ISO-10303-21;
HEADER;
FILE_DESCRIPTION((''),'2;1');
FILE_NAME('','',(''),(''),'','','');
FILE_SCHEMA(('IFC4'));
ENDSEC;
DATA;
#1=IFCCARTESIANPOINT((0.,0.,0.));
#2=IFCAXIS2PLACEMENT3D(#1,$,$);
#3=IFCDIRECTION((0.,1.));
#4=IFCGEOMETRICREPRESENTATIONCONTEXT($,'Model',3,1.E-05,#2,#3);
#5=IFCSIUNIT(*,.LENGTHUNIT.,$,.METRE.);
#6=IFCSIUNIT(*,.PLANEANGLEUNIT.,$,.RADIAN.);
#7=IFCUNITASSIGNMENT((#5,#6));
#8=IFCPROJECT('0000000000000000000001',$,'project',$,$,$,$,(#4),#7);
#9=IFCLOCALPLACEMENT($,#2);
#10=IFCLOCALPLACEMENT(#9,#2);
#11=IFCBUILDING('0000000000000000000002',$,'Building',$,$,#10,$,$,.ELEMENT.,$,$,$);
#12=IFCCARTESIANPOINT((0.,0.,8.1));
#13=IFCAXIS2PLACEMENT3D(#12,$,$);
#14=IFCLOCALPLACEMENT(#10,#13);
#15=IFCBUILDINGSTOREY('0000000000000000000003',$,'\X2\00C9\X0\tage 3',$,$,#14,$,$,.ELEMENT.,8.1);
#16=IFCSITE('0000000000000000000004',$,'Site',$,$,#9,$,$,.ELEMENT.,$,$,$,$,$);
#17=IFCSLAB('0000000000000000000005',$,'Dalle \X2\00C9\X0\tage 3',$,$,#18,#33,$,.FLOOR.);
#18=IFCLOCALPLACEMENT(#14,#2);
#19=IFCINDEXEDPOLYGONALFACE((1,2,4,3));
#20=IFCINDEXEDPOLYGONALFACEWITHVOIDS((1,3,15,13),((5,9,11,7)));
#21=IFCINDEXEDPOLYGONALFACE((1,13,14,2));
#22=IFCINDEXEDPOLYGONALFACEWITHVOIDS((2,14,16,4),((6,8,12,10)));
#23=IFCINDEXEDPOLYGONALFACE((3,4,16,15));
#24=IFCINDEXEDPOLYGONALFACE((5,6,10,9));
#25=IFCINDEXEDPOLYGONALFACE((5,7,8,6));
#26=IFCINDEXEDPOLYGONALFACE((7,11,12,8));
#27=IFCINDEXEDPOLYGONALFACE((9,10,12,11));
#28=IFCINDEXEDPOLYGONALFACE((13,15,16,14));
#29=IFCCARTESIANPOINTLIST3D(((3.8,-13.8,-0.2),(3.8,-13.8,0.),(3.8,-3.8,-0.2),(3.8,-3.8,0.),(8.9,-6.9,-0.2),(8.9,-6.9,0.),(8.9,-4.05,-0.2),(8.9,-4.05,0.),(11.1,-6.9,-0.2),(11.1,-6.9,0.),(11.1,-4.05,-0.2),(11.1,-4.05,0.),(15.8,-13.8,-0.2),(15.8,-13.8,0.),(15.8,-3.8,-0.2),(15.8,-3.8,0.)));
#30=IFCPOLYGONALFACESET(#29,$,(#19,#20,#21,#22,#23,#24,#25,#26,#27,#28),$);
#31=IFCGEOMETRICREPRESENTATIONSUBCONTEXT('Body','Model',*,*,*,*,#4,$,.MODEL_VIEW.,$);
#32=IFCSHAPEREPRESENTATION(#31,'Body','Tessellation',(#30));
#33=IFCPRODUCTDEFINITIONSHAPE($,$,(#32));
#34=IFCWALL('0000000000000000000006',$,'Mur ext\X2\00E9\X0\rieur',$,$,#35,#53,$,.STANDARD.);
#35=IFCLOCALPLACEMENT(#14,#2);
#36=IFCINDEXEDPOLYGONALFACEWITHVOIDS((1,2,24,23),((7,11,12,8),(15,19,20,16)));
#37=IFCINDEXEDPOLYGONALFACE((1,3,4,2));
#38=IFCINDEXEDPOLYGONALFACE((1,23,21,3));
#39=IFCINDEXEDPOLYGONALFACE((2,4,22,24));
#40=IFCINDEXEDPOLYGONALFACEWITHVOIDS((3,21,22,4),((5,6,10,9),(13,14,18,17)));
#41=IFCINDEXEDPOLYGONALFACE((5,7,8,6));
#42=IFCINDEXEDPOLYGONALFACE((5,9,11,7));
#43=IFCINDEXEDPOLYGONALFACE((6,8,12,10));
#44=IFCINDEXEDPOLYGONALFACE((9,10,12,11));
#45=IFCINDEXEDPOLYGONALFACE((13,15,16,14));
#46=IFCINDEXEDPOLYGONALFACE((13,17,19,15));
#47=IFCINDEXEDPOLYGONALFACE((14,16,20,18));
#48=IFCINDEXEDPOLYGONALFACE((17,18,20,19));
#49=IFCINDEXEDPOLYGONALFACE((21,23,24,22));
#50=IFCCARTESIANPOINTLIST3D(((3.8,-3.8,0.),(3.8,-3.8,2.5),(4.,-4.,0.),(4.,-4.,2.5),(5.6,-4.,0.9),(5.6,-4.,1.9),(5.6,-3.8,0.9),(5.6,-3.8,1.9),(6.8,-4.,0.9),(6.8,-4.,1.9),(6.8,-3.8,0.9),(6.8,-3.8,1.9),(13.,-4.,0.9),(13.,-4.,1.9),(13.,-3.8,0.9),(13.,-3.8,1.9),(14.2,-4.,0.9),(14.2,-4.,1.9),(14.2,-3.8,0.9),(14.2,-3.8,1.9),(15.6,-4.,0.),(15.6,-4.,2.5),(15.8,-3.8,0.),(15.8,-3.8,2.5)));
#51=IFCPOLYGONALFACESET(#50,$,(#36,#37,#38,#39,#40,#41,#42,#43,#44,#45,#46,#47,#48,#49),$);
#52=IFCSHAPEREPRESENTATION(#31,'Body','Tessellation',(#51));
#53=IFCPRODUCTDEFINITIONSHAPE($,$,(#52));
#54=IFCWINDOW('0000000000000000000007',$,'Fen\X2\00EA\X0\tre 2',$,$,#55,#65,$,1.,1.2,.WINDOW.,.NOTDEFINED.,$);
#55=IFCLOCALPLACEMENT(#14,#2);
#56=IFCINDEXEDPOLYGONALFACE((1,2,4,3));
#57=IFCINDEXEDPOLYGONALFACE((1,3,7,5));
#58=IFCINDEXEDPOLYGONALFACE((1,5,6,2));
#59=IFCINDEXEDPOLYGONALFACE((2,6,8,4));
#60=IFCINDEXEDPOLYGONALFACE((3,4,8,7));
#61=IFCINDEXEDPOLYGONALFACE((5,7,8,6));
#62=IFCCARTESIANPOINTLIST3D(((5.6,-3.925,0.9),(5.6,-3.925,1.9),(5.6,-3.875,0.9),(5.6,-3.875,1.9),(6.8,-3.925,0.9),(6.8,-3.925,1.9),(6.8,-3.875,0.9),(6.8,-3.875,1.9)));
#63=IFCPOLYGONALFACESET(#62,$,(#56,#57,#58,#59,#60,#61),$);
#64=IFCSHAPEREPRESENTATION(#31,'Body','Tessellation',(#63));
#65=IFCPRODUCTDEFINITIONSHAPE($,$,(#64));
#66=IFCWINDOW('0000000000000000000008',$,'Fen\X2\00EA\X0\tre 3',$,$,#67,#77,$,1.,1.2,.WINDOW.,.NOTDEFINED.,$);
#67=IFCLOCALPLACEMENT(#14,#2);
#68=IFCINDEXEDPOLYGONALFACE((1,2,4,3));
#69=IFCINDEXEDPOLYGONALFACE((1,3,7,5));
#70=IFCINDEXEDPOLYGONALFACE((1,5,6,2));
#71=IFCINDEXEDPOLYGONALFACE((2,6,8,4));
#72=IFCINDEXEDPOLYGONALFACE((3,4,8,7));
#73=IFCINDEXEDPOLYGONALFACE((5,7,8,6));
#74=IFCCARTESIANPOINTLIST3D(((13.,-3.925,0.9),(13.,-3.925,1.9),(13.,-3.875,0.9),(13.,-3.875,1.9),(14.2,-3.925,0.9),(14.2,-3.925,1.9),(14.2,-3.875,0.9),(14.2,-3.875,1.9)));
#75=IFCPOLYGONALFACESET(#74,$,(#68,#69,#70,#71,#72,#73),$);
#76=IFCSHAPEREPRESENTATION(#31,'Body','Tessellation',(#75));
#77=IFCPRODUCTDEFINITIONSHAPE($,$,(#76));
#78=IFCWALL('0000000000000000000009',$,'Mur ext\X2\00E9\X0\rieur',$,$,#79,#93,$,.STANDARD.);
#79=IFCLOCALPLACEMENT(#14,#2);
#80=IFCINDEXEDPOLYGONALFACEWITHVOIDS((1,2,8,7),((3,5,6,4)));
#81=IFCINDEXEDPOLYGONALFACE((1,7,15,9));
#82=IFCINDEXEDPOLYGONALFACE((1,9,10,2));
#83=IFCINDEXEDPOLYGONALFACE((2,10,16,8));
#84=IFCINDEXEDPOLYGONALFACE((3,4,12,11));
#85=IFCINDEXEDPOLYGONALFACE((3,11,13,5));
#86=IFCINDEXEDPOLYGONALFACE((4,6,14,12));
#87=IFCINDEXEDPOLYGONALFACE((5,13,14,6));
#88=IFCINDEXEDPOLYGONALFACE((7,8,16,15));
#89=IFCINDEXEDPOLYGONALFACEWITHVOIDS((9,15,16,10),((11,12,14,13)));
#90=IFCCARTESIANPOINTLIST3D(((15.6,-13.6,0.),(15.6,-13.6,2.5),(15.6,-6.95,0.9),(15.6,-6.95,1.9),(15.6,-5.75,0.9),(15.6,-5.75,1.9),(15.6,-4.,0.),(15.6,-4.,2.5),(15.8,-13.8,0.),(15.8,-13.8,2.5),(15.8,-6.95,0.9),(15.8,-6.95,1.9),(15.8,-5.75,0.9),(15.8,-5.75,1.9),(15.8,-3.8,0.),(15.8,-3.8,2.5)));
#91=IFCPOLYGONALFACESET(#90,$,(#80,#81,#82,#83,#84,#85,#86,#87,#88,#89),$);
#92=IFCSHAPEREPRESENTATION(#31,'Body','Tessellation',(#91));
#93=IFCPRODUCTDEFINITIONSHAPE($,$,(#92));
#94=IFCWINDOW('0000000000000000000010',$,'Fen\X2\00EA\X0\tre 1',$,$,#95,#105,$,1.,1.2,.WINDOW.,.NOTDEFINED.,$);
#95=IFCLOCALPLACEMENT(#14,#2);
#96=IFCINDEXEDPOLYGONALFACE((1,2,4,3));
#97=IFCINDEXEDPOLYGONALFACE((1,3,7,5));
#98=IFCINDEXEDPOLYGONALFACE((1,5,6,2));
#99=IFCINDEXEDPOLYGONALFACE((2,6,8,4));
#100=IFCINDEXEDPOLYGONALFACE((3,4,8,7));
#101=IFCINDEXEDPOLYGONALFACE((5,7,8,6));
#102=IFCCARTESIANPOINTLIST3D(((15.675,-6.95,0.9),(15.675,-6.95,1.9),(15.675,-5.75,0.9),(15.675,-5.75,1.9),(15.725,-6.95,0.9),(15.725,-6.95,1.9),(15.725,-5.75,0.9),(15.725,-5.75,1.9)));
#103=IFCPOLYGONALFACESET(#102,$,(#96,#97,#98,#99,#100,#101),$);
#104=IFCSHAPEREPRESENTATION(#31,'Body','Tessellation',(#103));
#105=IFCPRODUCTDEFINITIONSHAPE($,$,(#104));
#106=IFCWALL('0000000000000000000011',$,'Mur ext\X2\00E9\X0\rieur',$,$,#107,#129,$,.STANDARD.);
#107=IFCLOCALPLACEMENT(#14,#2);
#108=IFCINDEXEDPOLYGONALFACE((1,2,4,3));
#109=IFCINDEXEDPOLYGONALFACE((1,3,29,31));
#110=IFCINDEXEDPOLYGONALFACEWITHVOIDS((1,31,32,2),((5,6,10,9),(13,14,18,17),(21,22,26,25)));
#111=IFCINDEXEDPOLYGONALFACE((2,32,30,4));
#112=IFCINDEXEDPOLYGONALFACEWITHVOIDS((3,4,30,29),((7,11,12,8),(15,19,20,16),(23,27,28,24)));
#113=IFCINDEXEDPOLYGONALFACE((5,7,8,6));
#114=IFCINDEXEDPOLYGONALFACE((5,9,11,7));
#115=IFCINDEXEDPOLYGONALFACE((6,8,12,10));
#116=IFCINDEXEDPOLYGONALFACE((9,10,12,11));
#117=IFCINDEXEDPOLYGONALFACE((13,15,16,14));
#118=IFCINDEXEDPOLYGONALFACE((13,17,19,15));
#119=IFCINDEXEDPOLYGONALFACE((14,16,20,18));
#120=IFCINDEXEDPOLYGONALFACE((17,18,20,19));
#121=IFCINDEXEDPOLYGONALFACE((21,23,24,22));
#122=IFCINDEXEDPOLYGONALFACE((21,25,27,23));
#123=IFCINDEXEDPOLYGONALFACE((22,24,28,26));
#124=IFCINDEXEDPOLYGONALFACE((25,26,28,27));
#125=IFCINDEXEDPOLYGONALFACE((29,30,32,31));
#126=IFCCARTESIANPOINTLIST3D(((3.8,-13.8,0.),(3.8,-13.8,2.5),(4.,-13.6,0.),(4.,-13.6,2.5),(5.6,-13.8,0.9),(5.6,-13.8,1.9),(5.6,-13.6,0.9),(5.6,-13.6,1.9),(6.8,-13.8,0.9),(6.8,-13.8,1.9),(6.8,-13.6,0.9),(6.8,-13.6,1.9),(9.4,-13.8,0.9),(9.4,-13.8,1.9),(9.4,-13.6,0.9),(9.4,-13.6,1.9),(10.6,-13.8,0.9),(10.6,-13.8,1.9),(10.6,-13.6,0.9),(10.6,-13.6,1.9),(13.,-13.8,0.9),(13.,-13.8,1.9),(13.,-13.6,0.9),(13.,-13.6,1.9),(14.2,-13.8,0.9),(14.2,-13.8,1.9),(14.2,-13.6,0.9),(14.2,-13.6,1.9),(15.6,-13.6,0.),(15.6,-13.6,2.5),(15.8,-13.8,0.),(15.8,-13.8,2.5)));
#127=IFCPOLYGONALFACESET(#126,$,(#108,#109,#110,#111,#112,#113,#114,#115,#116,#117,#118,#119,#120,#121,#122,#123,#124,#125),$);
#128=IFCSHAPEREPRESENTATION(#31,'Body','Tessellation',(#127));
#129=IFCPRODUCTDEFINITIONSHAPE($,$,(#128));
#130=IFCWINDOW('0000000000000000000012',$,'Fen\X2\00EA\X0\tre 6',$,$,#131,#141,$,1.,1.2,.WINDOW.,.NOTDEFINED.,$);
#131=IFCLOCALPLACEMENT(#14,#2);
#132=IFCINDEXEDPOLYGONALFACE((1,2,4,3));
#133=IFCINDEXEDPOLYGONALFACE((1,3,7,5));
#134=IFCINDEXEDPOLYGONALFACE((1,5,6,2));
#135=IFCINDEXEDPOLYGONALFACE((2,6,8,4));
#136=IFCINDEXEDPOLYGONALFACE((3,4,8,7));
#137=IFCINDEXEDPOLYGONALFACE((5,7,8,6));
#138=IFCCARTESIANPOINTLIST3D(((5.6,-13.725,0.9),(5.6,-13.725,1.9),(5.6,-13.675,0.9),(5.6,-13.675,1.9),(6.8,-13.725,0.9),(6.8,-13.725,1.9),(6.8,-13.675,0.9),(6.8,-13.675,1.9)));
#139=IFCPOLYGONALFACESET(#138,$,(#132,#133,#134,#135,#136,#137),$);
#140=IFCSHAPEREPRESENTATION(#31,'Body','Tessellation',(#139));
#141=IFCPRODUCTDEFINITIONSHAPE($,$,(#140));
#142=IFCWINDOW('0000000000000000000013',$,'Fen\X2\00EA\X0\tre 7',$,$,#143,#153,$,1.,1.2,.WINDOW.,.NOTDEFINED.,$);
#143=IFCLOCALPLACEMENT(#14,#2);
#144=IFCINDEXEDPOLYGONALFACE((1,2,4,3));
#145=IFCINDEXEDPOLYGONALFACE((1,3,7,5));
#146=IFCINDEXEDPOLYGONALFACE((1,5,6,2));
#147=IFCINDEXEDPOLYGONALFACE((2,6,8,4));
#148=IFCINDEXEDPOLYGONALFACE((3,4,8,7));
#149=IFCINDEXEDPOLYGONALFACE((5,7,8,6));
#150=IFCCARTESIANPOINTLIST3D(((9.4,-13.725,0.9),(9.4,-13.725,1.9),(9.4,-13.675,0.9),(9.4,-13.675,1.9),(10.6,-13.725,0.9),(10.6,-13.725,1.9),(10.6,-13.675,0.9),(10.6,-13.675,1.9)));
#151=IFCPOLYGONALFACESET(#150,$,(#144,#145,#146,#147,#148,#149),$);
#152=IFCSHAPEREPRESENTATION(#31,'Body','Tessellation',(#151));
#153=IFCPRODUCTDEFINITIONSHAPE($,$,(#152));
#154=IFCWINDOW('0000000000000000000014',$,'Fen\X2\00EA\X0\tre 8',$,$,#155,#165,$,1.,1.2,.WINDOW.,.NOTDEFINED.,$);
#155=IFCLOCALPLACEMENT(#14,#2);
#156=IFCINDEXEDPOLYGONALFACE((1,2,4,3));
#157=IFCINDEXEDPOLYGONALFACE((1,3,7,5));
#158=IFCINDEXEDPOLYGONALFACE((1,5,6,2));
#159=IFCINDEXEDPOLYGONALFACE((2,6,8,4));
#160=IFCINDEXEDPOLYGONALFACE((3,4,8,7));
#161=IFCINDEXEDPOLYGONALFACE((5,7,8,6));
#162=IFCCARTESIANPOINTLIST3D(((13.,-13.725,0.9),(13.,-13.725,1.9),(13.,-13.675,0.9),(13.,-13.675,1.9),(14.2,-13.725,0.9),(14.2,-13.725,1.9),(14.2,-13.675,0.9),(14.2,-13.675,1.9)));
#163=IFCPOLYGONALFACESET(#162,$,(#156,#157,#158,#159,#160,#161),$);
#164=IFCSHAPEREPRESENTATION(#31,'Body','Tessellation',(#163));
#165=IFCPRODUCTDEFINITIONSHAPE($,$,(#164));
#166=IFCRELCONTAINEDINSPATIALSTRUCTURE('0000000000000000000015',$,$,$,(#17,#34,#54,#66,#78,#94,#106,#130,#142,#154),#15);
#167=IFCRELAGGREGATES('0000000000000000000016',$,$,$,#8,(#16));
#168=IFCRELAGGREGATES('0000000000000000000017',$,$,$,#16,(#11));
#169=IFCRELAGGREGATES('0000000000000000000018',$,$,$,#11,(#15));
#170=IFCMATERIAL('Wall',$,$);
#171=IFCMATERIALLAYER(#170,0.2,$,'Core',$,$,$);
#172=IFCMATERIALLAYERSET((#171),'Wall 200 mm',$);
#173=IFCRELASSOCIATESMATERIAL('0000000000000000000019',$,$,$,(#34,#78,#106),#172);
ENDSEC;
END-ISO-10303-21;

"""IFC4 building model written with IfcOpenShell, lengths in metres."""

from ifc_helpers import new_model, si_unit, direction, frame, origin, origin_2d, place, context, subcontext, project, spatial, polyline, rectangle, outline, extrude, material, layer, layer_set, layer_usage, element, fill, save


model = new_model("IFC4")

# Units and contexts
model_context = context("Model", 3, precision=1e-05, world=origin(), true_north=direction((0.0, 1.0)))
body_context = subcontext(model_context, "Body", "Model", "MODEL_VIEW")
ifc_project = project(units=[si_unit("LENGTHUNIT", "METRE"), si_unit("PLANEANGLEUNIT", "RADIAN")], contexts=[model_context])

# Site, building, storey
site_placement = place(None, origin())
site = spatial("IfcSite", under=ifc_project, at=site_placement, Name="Site", CompositionType="ELEMENT")
building_placement = place(site_placement, origin())
building = spatial("IfcBuilding", under=site, at=building_placement, Name="Building", CompositionType="ELEMENT")
storey_placement = place(building_placement, frame((0.0, 0.0, 8.1)))
storey = spatial("IfcBuildingStorey", under=building, at=storey_placement, Name="Étage 3", CompositionType="ELEMENT", Elevation=8.1)

# Slab
slab_placement = place(storey_placement, origin())
element("IfcSlab", 1, at=slab_placement, inside=storey, Name="Dalle Étage 3", PredefinedType="FLOOR", context=body_context, shape_type="SweptSolid", body=[
    extrude(outline(polyline([(3.8, -13.8), (15.8, -13.8), (15.8, -3.8), (3.8, -3.8), (3.8, -13.8)]), holes=[polyline([(11.1, -4.05), (11.1, -6.9), (8.9, -6.9), (8.9, -4.05), (11.1, -4.05)])]), frame((0.0, 0.0, -0.2)), (0.0, 0.0, 1.0), 0.2),
])

# Wall, openings, windows
ifc_material = material(Name="Wall")
ifc_layer = layer(ifc_material, 0.2, Name="Core")
ifc_layer_set = layer_set([ifc_layer], Name="Wall 200 mm")
ifc_layer_usage = layer_usage(ifc_layer_set, "AXIS2", "POSITIVE", -0.1)
wall_1_placement = place(storey_placement, frame((3.9, -3.9, 0.0)))
wall_1 = element("IfcWall", 2, at=wall_1_placement, inside=storey, material=ifc_layer_usage, Name="Mur extérieur", PredefinedType="STANDARD", context=body_context, shape_type="SweptSolid", body=[
    extrude(outline(polyline([(0.0, 0.0), (0.1, -0.1), (11.7, -0.1), (11.8, 0.0), (11.9, 0.1), (-0.1, 0.1), (0.0, 0.0)])), origin(), (0.0, 0.0, 1.0), 2.5),
])
opening_1_placement = place(wall_1_placement, frame((2.3, 0.0, 0.9)))
opening_1 = element("IfcOpeningElement", 3, at=opening_1_placement, cuts=wall_1, PredefinedType="OPENING", context=body_context, shape_type="SweptSolid", body=[
    extrude(rectangle(XDim=1.2, YDim=0.4, at=origin_2d()), origin(), (0.0, 0.0, 1.0), 1.0),
])
opening_2_placement = place(wall_1_placement, frame((9.7, 0.0, 0.9)))
opening_2 = element("IfcOpeningElement", 4, at=opening_2_placement, cuts=wall_1, PredefinedType="OPENING", context=body_context, shape_type="SweptSolid", body=[
    extrude(rectangle(XDim=1.2, YDim=0.4, at=origin_2d()), origin(), (0.0, 0.0, 1.0), 1.0),
])
window_1_placement = place(opening_1_placement, origin())
window_1 = element("IfcWindow", 5, at=window_1_placement, inside=storey, Name="Fenêtre 2", OverallHeight=1.0, OverallWidth=1.2, PartitioningType="NOTDEFINED", PredefinedType="WINDOW", context=body_context, shape_type="SweptSolid", body=[
    extrude(rectangle(XDim=1.2, YDim=0.05, at=origin_2d()), origin(), (0.0, 0.0, 1.0), 1.0),
])
fill(opening_1, window_1)
window_2_placement = place(opening_2_placement, origin())
window_2 = element("IfcWindow", 6, at=window_2_placement, inside=storey, Name="Fenêtre 3", OverallHeight=1.0, OverallWidth=1.2, PartitioningType="NOTDEFINED", PredefinedType="WINDOW", context=body_context, shape_type="SweptSolid", body=[
    extrude(rectangle(XDim=1.2, YDim=0.05, at=origin_2d()), origin(), (0.0, 0.0, 1.0), 1.0),
])
fill(opening_2, window_2)

# Wall, opening, window
wall_2_placement = place(storey_placement, frame((15.7, -3.9, 0.0), z_axis=(0.0, 0.0, 1.0), x_axis=(0.0, -1.0, 0.0)))
wall_2 = element("IfcWall", 7, at=wall_2_placement, inside=storey, material=ifc_layer_usage, Name="Mur extérieur", PredefinedType="STANDARD", context=body_context, shape_type="SweptSolid", body=[
    extrude(outline(polyline([(0.0, 0.0), (0.1, -0.1), (9.7, -0.1), (9.8, 0.0), (9.9, 0.1), (-0.1, 0.1), (0.0, 0.0)])), origin(), (0.0, 0.0, 1.0), 2.5),
])
opening_3_placement = place(wall_2_placement, frame((2.45, 0.0, 0.9)))
opening_3 = element("IfcOpeningElement", 8, at=opening_3_placement, cuts=wall_2, PredefinedType="OPENING", context=body_context, shape_type="SweptSolid", body=[
    extrude(rectangle(XDim=1.2, YDim=0.4, at=origin_2d()), origin(), (0.0, 0.0, 1.0), 1.0),
])
window_3_placement = place(opening_3_placement, origin())
window_3 = element("IfcWindow", 9, at=window_3_placement, inside=storey, Name="Fenêtre 1", OverallHeight=1.0, OverallWidth=1.2, PartitioningType="NOTDEFINED", PredefinedType="WINDOW", context=body_context, shape_type="SweptSolid", body=[
    extrude(rectangle(XDim=1.2, YDim=0.05, at=origin_2d()), origin(), (0.0, 0.0, 1.0), 1.0),
])
fill(opening_3, window_3)

# Wall, openings, windows
wall_3_placement = place(storey_placement, frame((15.7, -13.7, 0.0), z_axis=(0.0, 0.0, 1.0), x_axis=(-1.0, 0.0, 0.0)))
wall_3 = element("IfcWall", 10, at=wall_3_placement, inside=storey, material=ifc_layer_usage, Name="Mur extérieur", PredefinedType="STANDARD", context=body_context, shape_type="SweptSolid", body=[
    extrude(outline(polyline([(0.0, 0.0), (0.1, -0.1), (11.7, -0.1), (11.8, 0.0), (11.9, 0.1), (-0.1, 0.1), (0.0, 0.0)])), origin(), (0.0, 0.0, 1.0), 2.5),
])
opening_4_placement = place(wall_3_placement, frame((9.5, 0.0, 0.9), z_axis=(0.0, 0.0, 1.0), x_axis=(1.0, 0.0, 0.0)))
opening_4 = element("IfcOpeningElement", 11, at=opening_4_placement, cuts=wall_3, PredefinedType="OPENING", context=body_context, shape_type="SweptSolid", body=[
    extrude(rectangle(XDim=1.2, YDim=0.4, at=origin_2d()), origin(), (0.0, 0.0, 1.0), 1.0),
])
opening_5_placement = place(wall_3_placement, frame((5.7, 0.0, 0.9), z_axis=(0.0, 0.0, 1.0), x_axis=(1.0, 0.0, 0.0)))
opening_5 = element("IfcOpeningElement", 12, at=opening_5_placement, cuts=wall_3, PredefinedType="OPENING", context=body_context, shape_type="SweptSolid", body=[
    extrude(rectangle(XDim=1.2, YDim=0.4, at=origin_2d()), origin(), (0.0, 0.0, 1.0), 1.0),
])
opening_6_placement = place(wall_3_placement, frame((2.1, 0.0, 0.9), z_axis=(0.0, 0.0, 1.0), x_axis=(1.0, 0.0, 0.0)))
opening_6 = element("IfcOpeningElement", 13, at=opening_6_placement, cuts=wall_3, PredefinedType="OPENING", context=body_context, shape_type="SweptSolid", body=[
    extrude(rectangle(XDim=1.2, YDim=0.4, at=origin_2d()), origin(), (0.0, 0.0, 1.0), 1.0),
])
window_4_placement = place(opening_4_placement, origin())
window_4 = element("IfcWindow", 14, at=window_4_placement, inside=storey, Name="Fenêtre 6", OverallHeight=1.0, OverallWidth=1.2, PartitioningType="NOTDEFINED", PredefinedType="WINDOW", context=body_context, shape_type="SweptSolid", body=[
    extrude(rectangle(XDim=1.2, YDim=0.05, at=origin_2d()), origin(), (0.0, 0.0, 1.0), 1.0),
])
fill(opening_4, window_4)
window_5_placement = place(opening_5_placement, origin())
window_5 = element("IfcWindow", 15, at=window_5_placement, inside=storey, Name="Fenêtre 7", OverallHeight=1.0, OverallWidth=1.2, PartitioningType="NOTDEFINED", PredefinedType="WINDOW", context=body_context, shape_type="SweptSolid", body=[
    extrude(rectangle(XDim=1.2, YDim=0.05, at=origin_2d()), origin(), (0.0, 0.0, 1.0), 1.0),
])
fill(opening_5, window_5)
window_6_placement = place(opening_6_placement, origin())
window_6 = element("IfcWindow", 16, at=window_6_placement, inside=storey, Name="Fenêtre 8", OverallHeight=1.0, OverallWidth=1.2, PartitioningType="NOTDEFINED", PredefinedType="WINDOW", context=body_context, shape_type="SweptSolid", body=[
    extrude(rectangle(XDim=1.2, YDim=0.05, at=origin_2d()), origin(), (0.0, 0.0, 1.0), 1.0),
])
fill(opening_6, window_6)

save(model, "model.ifc")
